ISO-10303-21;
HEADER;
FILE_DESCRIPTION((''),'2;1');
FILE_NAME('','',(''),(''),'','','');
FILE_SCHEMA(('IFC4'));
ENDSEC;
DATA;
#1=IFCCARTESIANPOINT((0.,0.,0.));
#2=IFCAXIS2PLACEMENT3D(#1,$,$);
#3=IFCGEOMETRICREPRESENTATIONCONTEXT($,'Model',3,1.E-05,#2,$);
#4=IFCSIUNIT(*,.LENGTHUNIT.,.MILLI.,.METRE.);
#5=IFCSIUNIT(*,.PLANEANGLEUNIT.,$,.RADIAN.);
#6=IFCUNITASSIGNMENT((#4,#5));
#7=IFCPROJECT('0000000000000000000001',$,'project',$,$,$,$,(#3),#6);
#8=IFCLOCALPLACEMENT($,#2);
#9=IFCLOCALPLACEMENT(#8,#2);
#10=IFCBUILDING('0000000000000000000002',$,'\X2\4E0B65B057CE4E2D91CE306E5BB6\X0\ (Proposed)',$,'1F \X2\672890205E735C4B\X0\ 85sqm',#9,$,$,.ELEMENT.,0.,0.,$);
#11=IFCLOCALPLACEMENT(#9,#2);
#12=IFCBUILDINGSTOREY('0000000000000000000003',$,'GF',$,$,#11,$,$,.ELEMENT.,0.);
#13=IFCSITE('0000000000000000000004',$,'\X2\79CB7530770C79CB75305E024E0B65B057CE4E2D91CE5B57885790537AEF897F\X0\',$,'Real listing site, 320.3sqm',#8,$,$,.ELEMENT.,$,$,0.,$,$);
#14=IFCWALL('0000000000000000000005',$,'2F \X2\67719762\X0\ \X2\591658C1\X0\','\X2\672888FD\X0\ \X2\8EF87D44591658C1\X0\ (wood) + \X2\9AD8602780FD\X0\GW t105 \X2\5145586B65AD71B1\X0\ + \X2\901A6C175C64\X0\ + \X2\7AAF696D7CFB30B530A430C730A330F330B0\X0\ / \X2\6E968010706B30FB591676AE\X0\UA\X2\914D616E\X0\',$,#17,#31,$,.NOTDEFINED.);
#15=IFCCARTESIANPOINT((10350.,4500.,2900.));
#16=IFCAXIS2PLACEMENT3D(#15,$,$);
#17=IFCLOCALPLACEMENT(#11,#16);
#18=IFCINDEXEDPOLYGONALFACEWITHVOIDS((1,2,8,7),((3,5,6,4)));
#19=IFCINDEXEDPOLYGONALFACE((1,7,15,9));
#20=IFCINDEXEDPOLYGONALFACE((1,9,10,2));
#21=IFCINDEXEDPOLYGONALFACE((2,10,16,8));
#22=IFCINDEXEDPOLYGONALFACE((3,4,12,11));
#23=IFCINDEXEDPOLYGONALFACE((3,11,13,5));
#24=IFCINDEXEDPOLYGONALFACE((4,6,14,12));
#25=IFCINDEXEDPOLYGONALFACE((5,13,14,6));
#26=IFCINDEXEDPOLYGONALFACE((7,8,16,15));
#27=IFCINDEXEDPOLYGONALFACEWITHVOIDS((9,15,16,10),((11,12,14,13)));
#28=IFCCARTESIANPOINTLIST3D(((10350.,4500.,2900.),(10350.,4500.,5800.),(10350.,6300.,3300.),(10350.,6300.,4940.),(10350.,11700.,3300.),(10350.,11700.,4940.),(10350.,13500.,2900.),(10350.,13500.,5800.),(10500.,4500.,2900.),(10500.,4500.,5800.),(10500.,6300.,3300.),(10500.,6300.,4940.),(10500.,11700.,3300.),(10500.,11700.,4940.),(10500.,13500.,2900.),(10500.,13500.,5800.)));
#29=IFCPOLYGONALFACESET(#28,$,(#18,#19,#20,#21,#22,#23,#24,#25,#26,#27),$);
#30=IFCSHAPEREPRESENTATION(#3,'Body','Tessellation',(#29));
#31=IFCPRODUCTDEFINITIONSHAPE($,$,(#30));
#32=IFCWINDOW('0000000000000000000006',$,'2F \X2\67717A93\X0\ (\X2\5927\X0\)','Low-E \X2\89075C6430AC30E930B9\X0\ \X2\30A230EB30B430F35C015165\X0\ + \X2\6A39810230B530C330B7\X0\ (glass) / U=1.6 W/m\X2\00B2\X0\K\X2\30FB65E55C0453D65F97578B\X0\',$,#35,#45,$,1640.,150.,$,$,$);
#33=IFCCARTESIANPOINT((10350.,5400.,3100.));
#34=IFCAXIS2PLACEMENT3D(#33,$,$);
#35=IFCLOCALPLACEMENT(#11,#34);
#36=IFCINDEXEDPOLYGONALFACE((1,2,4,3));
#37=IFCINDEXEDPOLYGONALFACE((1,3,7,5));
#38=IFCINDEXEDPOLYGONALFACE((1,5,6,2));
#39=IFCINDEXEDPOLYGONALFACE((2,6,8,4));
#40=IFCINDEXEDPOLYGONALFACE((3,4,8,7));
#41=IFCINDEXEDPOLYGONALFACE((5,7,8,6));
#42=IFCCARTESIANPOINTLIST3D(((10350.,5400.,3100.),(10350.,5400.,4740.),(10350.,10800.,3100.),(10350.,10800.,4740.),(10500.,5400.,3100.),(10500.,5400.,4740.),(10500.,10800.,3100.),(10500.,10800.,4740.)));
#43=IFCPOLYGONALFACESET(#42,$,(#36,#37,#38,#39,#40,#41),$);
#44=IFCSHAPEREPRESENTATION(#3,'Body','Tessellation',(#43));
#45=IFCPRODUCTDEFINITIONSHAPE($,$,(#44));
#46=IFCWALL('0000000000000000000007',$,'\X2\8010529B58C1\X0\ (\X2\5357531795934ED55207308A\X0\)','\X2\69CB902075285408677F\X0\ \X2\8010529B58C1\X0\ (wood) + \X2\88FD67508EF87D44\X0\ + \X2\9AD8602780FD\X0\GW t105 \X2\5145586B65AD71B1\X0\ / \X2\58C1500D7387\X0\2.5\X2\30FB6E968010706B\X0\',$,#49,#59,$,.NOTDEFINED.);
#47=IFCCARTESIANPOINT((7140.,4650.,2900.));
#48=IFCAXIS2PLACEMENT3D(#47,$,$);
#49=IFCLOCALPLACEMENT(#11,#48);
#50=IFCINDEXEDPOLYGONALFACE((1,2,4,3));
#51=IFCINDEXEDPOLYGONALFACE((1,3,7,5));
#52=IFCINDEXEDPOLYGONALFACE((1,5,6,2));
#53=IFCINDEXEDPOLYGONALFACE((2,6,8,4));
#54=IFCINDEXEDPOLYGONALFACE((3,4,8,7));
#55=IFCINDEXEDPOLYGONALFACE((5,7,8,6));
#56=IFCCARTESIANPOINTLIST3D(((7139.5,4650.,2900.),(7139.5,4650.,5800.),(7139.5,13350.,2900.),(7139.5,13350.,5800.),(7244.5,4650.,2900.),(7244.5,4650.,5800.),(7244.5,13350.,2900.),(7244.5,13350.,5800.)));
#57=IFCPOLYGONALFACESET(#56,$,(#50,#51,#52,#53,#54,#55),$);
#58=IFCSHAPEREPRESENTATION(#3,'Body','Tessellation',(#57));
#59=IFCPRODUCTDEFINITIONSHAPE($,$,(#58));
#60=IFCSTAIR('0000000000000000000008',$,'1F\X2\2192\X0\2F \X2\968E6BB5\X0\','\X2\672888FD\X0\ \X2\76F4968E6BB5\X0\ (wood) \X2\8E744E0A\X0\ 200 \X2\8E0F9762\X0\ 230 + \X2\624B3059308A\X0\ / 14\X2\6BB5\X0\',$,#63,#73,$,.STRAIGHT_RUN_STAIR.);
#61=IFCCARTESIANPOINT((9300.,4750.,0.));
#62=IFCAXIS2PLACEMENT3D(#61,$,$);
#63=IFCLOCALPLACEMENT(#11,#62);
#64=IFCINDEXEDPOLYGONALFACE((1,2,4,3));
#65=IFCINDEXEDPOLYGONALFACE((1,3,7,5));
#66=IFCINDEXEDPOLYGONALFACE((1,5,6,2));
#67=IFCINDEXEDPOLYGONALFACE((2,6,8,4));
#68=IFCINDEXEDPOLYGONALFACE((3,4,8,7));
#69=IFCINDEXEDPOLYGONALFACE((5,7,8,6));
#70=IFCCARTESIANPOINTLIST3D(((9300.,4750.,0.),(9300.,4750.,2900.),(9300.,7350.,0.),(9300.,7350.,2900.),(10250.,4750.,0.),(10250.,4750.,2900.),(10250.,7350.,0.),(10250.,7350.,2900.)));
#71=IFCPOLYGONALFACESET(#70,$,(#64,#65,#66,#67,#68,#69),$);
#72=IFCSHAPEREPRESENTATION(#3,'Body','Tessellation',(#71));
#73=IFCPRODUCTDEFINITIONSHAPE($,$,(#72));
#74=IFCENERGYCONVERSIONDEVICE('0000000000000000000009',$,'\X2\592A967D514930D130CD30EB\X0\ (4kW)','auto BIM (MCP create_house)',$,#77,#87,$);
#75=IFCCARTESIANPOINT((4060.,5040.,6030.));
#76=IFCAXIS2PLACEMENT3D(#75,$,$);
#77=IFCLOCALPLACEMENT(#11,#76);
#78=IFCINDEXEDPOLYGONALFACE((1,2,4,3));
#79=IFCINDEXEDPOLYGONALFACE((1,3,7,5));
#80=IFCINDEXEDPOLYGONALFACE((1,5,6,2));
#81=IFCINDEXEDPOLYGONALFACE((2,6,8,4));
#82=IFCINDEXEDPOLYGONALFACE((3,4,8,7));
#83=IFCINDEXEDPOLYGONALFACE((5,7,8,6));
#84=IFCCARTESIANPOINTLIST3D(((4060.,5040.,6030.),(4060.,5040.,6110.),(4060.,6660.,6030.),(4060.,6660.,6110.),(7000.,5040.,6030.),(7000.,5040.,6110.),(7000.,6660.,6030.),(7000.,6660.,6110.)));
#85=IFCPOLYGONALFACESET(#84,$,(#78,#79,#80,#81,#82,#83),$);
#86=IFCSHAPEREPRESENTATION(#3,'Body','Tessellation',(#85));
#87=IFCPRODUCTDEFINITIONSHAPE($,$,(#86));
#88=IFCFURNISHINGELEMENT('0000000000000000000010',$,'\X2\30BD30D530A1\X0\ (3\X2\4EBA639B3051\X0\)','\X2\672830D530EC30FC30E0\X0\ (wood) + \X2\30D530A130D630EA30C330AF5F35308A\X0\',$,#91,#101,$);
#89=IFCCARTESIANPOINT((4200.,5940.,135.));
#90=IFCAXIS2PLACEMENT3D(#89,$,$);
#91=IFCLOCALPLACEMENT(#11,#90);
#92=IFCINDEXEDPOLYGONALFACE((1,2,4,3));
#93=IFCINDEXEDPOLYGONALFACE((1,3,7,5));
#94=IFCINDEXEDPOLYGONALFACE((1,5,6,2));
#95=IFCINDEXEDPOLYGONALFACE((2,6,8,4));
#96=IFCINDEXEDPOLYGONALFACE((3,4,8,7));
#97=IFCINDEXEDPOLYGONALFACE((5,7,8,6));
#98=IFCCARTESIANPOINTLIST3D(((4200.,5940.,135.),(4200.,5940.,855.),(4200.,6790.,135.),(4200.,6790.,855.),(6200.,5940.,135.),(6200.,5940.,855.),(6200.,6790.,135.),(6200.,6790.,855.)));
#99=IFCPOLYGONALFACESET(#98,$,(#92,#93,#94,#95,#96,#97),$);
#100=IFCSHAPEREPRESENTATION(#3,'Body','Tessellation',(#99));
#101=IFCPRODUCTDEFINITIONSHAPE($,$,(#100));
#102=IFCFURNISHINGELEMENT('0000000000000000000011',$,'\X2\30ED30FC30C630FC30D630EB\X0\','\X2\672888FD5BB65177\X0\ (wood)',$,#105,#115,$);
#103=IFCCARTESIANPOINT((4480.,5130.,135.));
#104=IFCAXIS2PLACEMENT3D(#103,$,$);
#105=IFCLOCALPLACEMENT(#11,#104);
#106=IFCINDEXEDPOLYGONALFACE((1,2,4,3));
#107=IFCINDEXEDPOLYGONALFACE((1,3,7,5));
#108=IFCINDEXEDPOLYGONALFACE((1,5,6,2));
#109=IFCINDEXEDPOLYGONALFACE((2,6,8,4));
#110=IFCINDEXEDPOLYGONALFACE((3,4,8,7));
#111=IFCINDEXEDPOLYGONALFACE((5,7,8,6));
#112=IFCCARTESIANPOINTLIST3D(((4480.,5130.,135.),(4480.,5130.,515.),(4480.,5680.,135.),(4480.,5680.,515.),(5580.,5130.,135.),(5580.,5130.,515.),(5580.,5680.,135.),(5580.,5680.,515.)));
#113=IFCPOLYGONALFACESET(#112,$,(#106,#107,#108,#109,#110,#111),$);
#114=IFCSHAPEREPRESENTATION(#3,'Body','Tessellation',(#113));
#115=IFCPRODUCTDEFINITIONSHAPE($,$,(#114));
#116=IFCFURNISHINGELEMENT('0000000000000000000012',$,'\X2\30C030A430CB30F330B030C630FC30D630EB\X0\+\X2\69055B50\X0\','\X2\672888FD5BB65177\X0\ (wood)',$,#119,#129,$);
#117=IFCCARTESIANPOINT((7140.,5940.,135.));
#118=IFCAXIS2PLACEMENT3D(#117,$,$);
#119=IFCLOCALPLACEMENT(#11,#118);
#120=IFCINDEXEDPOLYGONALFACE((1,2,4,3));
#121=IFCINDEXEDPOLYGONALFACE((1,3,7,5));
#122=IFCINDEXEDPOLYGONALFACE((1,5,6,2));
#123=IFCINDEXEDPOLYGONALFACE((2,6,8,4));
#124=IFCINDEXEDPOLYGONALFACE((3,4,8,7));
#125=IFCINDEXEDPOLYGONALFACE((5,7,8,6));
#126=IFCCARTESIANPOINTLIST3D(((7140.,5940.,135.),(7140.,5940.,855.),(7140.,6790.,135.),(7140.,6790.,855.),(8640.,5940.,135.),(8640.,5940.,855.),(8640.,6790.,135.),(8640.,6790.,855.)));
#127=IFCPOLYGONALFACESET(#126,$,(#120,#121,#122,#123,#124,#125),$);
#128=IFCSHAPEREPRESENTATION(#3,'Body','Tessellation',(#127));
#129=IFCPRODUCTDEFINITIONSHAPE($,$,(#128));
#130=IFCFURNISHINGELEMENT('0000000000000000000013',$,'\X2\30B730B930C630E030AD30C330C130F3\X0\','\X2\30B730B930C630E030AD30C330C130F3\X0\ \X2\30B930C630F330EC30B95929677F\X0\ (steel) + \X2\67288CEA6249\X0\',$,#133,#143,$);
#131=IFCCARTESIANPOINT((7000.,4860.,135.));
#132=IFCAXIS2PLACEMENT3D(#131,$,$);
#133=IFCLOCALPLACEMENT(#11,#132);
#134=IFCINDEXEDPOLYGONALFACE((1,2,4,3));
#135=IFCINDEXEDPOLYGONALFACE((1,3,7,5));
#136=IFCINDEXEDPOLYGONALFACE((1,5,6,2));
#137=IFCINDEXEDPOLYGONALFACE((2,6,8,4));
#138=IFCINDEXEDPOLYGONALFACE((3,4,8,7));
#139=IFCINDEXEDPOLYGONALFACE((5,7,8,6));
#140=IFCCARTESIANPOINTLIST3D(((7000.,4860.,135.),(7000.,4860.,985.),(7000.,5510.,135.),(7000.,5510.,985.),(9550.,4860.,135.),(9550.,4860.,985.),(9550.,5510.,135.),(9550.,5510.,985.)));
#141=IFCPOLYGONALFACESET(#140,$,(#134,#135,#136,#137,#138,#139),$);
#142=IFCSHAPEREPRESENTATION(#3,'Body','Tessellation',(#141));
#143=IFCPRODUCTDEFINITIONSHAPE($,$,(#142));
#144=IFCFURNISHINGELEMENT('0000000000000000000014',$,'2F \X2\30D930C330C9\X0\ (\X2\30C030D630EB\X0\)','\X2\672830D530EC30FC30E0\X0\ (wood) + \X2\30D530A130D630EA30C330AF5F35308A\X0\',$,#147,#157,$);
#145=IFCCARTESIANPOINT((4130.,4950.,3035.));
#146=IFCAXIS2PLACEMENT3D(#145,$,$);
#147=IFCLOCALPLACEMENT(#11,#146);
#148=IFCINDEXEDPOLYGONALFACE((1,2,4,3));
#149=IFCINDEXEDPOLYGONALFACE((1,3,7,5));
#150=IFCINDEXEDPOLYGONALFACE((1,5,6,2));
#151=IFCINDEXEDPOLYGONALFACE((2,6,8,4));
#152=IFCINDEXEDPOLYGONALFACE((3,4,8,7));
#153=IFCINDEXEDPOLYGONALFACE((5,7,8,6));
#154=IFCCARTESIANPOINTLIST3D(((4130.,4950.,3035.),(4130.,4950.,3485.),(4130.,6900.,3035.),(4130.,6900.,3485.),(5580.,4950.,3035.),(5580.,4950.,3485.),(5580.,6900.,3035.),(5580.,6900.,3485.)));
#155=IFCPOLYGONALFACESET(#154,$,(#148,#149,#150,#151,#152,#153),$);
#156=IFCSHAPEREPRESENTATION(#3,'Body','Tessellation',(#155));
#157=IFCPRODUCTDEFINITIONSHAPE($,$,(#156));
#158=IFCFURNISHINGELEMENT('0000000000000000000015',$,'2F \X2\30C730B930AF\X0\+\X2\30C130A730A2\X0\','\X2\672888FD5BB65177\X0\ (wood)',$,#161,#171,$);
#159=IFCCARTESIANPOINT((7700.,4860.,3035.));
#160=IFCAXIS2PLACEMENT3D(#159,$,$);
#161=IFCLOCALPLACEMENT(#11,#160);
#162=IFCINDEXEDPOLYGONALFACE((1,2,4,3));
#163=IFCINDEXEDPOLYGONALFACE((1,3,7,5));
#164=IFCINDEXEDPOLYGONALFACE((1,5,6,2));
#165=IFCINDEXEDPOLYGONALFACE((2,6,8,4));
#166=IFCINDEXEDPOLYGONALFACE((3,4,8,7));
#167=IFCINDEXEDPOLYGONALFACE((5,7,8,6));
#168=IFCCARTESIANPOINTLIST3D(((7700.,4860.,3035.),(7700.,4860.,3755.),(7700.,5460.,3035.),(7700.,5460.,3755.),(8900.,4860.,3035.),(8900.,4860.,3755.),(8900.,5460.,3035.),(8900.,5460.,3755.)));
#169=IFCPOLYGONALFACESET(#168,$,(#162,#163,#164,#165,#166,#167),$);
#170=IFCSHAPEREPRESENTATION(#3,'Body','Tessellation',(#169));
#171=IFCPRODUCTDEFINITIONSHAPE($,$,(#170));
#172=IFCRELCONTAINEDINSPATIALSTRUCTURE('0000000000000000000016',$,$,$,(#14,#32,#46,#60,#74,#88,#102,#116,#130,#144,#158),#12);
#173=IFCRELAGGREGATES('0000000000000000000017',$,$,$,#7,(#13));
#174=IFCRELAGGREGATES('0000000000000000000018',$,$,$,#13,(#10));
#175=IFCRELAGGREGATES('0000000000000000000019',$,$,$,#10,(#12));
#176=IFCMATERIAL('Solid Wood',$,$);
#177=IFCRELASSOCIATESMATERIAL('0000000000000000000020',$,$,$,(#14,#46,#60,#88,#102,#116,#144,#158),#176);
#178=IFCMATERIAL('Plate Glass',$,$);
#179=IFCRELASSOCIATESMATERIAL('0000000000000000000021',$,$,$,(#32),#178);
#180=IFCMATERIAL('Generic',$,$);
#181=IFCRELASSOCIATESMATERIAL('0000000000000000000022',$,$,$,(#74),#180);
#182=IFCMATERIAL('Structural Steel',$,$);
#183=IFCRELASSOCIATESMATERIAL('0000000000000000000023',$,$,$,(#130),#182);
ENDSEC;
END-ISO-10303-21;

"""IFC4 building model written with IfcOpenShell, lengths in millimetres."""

from ifc_helpers import new_model, si_unit, frame, frame_2d, origin, place, context, project, spatial, rectangle, extrude, material, element, fill, save


model = new_model("IFC4")

# Units and contexts
model_context = context("Model", 3, precision=1e-05, world=origin())
ifc_project = project(units=[si_unit("LENGTHUNIT", "METRE", prefix="MILLI"), si_unit("PLANEANGLEUNIT", "RADIAN")], contexts=[model_context])

# Site, building, storey
site_placement = place(None, origin())
site = spatial("IfcSite", under=ifc_project, at=site_placement, Name="秋田県秋田市下新城中野字街道端西", ObjectType="Real listing site, 320.3sqm", CompositionType="ELEMENT", RefElevation=0.0)
building_placement = place(site_placement, origin())
building = spatial("IfcBuilding", under=site, at=building_placement, Name="下新城中野の家 (Proposed)", ObjectType="1F 木造平屋 85sqm", CompositionType="ELEMENT", ElevationOfRefHeight=0.0, ElevationOfTerrain=0.0)
storey_placement = place(building_placement, origin())
storey = spatial("IfcBuildingStorey", under=building, at=storey_placement, Name="GF", CompositionType="ELEMENT", Elevation=0.0)

# Shared definitions
ifc_material_1 = material(Name="Solid Wood")
ifc_material_2 = material(Name="Plate Glass")

# Wall, opening, window
wall_1_placement = place(storey_placement, frame((10350.0, 4500.0, 2900.0)))
wall_1 = element("IfcWall", 1, at=wall_1_placement, inside=storey, material=ifc_material_1, Name="2F 東面 外壁", Description="木製 軸組外壁 (wood) + 高性能GW t105 充填断熱 + 通気層 + 窯業系サイディング / 準耐火・外皮UA配慮", PredefinedType="NOTDEFINED", context=model_context, shape_type="SweptSolid", body=[
    extrude(rectangle(XDim=150.0, YDim=9000.0, at=frame_2d((75.0, 4500.0))), frame((10350.0, 4500.0, 2900.0)), (0.0, 0.0, 1.0), 2900.0),
])
opening_1_placement = place(storey_placement, frame((10350.0, 5400.0, 3100.0)))
opening_1 = element("IfcOpeningElement", 2, at=opening_1_placement, cuts=wall_1, PredefinedType="NOTDEFINED", context=model_context, shape_type="SweptSolid", body=[
    extrude(rectangle(XDim=150.0, YDim=5400.0, at=frame_2d((75.0, 2700.0))), frame((10350.0, 5400.0, 3100.0)), (0.0, 0.0, 1.0), 1640.0),
])
window_1_placement = place(storey_placement, frame((10350.0, 5400.0, 3100.0)))
window_1 = element("IfcWindow", 3, at=window_1_placement, inside=storey, material=ifc_material_2, Name="2F 東窓 (大)", Description="Low-E 複層ガラス アルゴン封入 + 樹脂サッシ (glass) / U=1.6 W/m²K・日射取得型", OverallHeight=1640.0, OverallWidth=150.0, context=model_context, shape_type="SweptSolid", body=[
    extrude(rectangle(XDim=150.0, YDim=5400.0, at=frame_2d((75.0, 2700.0))), frame((10350.0, 5400.0, 3100.0)), (0.0, 0.0, 1.0), 1640.0),
])
fill(opening_1, window_1)

# Wall
wall_2_placement = place(storey_placement, frame((7140.0, 4650.0, 2900.0)))
element("IfcWall", 4, at=wall_2_placement, inside=storey, material=ifc_material_1, Name="耐力壁 (南北間仕切り)", Description="構造用合板 耐力壁 (wood) + 製材軸組 + 高性能GW t105 充填断熱 / 壁倍率2.5・準耐火", PredefinedType="NOTDEFINED", context=model_context, shape_type="SweptSolid", body=[
    extrude(rectangle(XDim=105.0, YDim=8700.0, at=frame_2d((52.0, 4350.0))), frame((7140.0, 4650.0, 2900.0)), (0.0, 0.0, 1.0), 2900.0),
])

# Stair
stair_placement = place(storey_placement, frame((9300.0, 4750.0, 0.0)))
element("IfcStair", 5, at=stair_placement, inside=storey, material=ifc_material_1, Name="1F→2F 階段", Description="木製 直階段 (wood) 蹴上 200 踏面 230 + 手すり / 14段", PredefinedType="STRAIGHT_RUN_STAIR", context=model_context, shape_type="SweptSolid", body=[
    extrude(rectangle(XDim=950.0, YDim=2600.0, at=frame_2d((475.0, 1300.0))), frame((9300.0, 4750.0, 0.0)), (0.0, 0.0, 1.0), 2900.0),
])

# Energy conversion device
ifc_material_3 = material(Name="Generic")
energy_conversion_device_placement = place(storey_placement, frame((4060.0, 5040.0, 6030.0)))
element("IfcEnergyConversionDevice", 6, at=energy_conversion_device_placement, inside=storey, material=ifc_material_3, Name="太陽光パネル (4kW)", Description="auto BIM (MCP create_house)", context=model_context, shape_type="SweptSolid", body=[
    extrude(rectangle(XDim=2940.0, YDim=1620.0, at=frame_2d((1470.0, 810.0))), frame((4060.0, 5040.0, 6030.0)), (0.0, 0.0, 1.0), 80.0),
])

# Furnishing elements
furnishing_1_placement = place(storey_placement, frame((4200.0, 5940.0, 135.0)))
element("IfcFurnishingElement", 7, at=furnishing_1_placement, inside=storey, material=ifc_material_1, Name="ソファ (3人掛け)", Description="木フレーム (wood) + ファブリック張り", context=model_context, shape_type="SweptSolid", body=[
    extrude(rectangle(XDim=2000.0, YDim=850.0, at=frame_2d((1000.0, 425.0))), frame((4200.0, 5940.0, 135.0)), (0.0, 0.0, 1.0), 720.0),
])
furnishing_2_placement = place(storey_placement, frame((4480.0, 5130.0, 135.0)))
element("IfcFurnishingElement", 8, at=furnishing_2_placement, inside=storey, material=ifc_material_1, Name="ローテーブル", Description="木製家具 (wood)", context=model_context, shape_type="SweptSolid", body=[
    extrude(rectangle(XDim=1100.0, YDim=550.0, at=frame_2d((550.0, 275.0))), frame((4480.0, 5130.0, 135.0)), (0.0, 0.0, 1.0), 380.0),
])
furnishing_3_placement = place(storey_placement, frame((7140.0, 5940.0, 135.0)))
element("IfcFurnishingElement", 9, at=furnishing_3_placement, inside=storey, material=ifc_material_1, Name="ダイニングテーブル+椅子", Description="木製家具 (wood)", context=model_context, shape_type="SweptSolid", body=[
    extrude(rectangle(XDim=1500.0, YDim=850.0, at=frame_2d((750.0, 425.0))), frame((7140.0, 5940.0, 135.0)), (0.0, 0.0, 1.0), 720.0),
])
ifc_material_4 = material(Name="Structural Steel")
furnishing_4_placement = place(storey_placement, frame((7000.0, 4860.0, 135.0)))
element("IfcFurnishingElement", 10, at=furnishing_4_placement, inside=storey, material=ifc_material_4, Name="システムキッチン", Description="システムキッチン ステンレス天板 (steel) + 木質扉", context=model_context, shape_type="SweptSolid", body=[
    extrude(rectangle(XDim=2550.0, YDim=650.0, at=frame_2d((1275.0, 325.0))), frame((7000.0, 4860.0, 135.0)), (0.0, 0.0, 1.0), 850.0),
])
furnishing_5_placement = place(storey_placement, frame((4130.0, 4950.0, 3035.0)))
element("IfcFurnishingElement", 11, at=furnishing_5_placement, inside=storey, material=ifc_material_1, Name="2F ベッド (ダブル)", Description="木フレーム (wood) + ファブリック張り", context=model_context, shape_type="SweptSolid", body=[
    extrude(rectangle(XDim=1450.0, YDim=1950.0, at=frame_2d((725.0, 975.0))), frame((4130.0, 4950.0, 3035.0)), (0.0, 0.0, 1.0), 450.0),
])
furnishing_6_placement = place(storey_placement, frame((7700.0, 4860.0, 3035.0)))
element("IfcFurnishingElement", 12, at=furnishing_6_placement, inside=storey, material=ifc_material_1, Name="2F デスク+チェア", Description="木製家具 (wood)", context=model_context, shape_type="SweptSolid", body=[
    extrude(rectangle(XDim=1200.0, YDim=600.0, at=frame_2d((600.0, 300.0))), frame((7700.0, 4860.0, 3035.0)), (0.0, 0.0, 1.0), 720.0),
])

save(model, "model.ifc")
